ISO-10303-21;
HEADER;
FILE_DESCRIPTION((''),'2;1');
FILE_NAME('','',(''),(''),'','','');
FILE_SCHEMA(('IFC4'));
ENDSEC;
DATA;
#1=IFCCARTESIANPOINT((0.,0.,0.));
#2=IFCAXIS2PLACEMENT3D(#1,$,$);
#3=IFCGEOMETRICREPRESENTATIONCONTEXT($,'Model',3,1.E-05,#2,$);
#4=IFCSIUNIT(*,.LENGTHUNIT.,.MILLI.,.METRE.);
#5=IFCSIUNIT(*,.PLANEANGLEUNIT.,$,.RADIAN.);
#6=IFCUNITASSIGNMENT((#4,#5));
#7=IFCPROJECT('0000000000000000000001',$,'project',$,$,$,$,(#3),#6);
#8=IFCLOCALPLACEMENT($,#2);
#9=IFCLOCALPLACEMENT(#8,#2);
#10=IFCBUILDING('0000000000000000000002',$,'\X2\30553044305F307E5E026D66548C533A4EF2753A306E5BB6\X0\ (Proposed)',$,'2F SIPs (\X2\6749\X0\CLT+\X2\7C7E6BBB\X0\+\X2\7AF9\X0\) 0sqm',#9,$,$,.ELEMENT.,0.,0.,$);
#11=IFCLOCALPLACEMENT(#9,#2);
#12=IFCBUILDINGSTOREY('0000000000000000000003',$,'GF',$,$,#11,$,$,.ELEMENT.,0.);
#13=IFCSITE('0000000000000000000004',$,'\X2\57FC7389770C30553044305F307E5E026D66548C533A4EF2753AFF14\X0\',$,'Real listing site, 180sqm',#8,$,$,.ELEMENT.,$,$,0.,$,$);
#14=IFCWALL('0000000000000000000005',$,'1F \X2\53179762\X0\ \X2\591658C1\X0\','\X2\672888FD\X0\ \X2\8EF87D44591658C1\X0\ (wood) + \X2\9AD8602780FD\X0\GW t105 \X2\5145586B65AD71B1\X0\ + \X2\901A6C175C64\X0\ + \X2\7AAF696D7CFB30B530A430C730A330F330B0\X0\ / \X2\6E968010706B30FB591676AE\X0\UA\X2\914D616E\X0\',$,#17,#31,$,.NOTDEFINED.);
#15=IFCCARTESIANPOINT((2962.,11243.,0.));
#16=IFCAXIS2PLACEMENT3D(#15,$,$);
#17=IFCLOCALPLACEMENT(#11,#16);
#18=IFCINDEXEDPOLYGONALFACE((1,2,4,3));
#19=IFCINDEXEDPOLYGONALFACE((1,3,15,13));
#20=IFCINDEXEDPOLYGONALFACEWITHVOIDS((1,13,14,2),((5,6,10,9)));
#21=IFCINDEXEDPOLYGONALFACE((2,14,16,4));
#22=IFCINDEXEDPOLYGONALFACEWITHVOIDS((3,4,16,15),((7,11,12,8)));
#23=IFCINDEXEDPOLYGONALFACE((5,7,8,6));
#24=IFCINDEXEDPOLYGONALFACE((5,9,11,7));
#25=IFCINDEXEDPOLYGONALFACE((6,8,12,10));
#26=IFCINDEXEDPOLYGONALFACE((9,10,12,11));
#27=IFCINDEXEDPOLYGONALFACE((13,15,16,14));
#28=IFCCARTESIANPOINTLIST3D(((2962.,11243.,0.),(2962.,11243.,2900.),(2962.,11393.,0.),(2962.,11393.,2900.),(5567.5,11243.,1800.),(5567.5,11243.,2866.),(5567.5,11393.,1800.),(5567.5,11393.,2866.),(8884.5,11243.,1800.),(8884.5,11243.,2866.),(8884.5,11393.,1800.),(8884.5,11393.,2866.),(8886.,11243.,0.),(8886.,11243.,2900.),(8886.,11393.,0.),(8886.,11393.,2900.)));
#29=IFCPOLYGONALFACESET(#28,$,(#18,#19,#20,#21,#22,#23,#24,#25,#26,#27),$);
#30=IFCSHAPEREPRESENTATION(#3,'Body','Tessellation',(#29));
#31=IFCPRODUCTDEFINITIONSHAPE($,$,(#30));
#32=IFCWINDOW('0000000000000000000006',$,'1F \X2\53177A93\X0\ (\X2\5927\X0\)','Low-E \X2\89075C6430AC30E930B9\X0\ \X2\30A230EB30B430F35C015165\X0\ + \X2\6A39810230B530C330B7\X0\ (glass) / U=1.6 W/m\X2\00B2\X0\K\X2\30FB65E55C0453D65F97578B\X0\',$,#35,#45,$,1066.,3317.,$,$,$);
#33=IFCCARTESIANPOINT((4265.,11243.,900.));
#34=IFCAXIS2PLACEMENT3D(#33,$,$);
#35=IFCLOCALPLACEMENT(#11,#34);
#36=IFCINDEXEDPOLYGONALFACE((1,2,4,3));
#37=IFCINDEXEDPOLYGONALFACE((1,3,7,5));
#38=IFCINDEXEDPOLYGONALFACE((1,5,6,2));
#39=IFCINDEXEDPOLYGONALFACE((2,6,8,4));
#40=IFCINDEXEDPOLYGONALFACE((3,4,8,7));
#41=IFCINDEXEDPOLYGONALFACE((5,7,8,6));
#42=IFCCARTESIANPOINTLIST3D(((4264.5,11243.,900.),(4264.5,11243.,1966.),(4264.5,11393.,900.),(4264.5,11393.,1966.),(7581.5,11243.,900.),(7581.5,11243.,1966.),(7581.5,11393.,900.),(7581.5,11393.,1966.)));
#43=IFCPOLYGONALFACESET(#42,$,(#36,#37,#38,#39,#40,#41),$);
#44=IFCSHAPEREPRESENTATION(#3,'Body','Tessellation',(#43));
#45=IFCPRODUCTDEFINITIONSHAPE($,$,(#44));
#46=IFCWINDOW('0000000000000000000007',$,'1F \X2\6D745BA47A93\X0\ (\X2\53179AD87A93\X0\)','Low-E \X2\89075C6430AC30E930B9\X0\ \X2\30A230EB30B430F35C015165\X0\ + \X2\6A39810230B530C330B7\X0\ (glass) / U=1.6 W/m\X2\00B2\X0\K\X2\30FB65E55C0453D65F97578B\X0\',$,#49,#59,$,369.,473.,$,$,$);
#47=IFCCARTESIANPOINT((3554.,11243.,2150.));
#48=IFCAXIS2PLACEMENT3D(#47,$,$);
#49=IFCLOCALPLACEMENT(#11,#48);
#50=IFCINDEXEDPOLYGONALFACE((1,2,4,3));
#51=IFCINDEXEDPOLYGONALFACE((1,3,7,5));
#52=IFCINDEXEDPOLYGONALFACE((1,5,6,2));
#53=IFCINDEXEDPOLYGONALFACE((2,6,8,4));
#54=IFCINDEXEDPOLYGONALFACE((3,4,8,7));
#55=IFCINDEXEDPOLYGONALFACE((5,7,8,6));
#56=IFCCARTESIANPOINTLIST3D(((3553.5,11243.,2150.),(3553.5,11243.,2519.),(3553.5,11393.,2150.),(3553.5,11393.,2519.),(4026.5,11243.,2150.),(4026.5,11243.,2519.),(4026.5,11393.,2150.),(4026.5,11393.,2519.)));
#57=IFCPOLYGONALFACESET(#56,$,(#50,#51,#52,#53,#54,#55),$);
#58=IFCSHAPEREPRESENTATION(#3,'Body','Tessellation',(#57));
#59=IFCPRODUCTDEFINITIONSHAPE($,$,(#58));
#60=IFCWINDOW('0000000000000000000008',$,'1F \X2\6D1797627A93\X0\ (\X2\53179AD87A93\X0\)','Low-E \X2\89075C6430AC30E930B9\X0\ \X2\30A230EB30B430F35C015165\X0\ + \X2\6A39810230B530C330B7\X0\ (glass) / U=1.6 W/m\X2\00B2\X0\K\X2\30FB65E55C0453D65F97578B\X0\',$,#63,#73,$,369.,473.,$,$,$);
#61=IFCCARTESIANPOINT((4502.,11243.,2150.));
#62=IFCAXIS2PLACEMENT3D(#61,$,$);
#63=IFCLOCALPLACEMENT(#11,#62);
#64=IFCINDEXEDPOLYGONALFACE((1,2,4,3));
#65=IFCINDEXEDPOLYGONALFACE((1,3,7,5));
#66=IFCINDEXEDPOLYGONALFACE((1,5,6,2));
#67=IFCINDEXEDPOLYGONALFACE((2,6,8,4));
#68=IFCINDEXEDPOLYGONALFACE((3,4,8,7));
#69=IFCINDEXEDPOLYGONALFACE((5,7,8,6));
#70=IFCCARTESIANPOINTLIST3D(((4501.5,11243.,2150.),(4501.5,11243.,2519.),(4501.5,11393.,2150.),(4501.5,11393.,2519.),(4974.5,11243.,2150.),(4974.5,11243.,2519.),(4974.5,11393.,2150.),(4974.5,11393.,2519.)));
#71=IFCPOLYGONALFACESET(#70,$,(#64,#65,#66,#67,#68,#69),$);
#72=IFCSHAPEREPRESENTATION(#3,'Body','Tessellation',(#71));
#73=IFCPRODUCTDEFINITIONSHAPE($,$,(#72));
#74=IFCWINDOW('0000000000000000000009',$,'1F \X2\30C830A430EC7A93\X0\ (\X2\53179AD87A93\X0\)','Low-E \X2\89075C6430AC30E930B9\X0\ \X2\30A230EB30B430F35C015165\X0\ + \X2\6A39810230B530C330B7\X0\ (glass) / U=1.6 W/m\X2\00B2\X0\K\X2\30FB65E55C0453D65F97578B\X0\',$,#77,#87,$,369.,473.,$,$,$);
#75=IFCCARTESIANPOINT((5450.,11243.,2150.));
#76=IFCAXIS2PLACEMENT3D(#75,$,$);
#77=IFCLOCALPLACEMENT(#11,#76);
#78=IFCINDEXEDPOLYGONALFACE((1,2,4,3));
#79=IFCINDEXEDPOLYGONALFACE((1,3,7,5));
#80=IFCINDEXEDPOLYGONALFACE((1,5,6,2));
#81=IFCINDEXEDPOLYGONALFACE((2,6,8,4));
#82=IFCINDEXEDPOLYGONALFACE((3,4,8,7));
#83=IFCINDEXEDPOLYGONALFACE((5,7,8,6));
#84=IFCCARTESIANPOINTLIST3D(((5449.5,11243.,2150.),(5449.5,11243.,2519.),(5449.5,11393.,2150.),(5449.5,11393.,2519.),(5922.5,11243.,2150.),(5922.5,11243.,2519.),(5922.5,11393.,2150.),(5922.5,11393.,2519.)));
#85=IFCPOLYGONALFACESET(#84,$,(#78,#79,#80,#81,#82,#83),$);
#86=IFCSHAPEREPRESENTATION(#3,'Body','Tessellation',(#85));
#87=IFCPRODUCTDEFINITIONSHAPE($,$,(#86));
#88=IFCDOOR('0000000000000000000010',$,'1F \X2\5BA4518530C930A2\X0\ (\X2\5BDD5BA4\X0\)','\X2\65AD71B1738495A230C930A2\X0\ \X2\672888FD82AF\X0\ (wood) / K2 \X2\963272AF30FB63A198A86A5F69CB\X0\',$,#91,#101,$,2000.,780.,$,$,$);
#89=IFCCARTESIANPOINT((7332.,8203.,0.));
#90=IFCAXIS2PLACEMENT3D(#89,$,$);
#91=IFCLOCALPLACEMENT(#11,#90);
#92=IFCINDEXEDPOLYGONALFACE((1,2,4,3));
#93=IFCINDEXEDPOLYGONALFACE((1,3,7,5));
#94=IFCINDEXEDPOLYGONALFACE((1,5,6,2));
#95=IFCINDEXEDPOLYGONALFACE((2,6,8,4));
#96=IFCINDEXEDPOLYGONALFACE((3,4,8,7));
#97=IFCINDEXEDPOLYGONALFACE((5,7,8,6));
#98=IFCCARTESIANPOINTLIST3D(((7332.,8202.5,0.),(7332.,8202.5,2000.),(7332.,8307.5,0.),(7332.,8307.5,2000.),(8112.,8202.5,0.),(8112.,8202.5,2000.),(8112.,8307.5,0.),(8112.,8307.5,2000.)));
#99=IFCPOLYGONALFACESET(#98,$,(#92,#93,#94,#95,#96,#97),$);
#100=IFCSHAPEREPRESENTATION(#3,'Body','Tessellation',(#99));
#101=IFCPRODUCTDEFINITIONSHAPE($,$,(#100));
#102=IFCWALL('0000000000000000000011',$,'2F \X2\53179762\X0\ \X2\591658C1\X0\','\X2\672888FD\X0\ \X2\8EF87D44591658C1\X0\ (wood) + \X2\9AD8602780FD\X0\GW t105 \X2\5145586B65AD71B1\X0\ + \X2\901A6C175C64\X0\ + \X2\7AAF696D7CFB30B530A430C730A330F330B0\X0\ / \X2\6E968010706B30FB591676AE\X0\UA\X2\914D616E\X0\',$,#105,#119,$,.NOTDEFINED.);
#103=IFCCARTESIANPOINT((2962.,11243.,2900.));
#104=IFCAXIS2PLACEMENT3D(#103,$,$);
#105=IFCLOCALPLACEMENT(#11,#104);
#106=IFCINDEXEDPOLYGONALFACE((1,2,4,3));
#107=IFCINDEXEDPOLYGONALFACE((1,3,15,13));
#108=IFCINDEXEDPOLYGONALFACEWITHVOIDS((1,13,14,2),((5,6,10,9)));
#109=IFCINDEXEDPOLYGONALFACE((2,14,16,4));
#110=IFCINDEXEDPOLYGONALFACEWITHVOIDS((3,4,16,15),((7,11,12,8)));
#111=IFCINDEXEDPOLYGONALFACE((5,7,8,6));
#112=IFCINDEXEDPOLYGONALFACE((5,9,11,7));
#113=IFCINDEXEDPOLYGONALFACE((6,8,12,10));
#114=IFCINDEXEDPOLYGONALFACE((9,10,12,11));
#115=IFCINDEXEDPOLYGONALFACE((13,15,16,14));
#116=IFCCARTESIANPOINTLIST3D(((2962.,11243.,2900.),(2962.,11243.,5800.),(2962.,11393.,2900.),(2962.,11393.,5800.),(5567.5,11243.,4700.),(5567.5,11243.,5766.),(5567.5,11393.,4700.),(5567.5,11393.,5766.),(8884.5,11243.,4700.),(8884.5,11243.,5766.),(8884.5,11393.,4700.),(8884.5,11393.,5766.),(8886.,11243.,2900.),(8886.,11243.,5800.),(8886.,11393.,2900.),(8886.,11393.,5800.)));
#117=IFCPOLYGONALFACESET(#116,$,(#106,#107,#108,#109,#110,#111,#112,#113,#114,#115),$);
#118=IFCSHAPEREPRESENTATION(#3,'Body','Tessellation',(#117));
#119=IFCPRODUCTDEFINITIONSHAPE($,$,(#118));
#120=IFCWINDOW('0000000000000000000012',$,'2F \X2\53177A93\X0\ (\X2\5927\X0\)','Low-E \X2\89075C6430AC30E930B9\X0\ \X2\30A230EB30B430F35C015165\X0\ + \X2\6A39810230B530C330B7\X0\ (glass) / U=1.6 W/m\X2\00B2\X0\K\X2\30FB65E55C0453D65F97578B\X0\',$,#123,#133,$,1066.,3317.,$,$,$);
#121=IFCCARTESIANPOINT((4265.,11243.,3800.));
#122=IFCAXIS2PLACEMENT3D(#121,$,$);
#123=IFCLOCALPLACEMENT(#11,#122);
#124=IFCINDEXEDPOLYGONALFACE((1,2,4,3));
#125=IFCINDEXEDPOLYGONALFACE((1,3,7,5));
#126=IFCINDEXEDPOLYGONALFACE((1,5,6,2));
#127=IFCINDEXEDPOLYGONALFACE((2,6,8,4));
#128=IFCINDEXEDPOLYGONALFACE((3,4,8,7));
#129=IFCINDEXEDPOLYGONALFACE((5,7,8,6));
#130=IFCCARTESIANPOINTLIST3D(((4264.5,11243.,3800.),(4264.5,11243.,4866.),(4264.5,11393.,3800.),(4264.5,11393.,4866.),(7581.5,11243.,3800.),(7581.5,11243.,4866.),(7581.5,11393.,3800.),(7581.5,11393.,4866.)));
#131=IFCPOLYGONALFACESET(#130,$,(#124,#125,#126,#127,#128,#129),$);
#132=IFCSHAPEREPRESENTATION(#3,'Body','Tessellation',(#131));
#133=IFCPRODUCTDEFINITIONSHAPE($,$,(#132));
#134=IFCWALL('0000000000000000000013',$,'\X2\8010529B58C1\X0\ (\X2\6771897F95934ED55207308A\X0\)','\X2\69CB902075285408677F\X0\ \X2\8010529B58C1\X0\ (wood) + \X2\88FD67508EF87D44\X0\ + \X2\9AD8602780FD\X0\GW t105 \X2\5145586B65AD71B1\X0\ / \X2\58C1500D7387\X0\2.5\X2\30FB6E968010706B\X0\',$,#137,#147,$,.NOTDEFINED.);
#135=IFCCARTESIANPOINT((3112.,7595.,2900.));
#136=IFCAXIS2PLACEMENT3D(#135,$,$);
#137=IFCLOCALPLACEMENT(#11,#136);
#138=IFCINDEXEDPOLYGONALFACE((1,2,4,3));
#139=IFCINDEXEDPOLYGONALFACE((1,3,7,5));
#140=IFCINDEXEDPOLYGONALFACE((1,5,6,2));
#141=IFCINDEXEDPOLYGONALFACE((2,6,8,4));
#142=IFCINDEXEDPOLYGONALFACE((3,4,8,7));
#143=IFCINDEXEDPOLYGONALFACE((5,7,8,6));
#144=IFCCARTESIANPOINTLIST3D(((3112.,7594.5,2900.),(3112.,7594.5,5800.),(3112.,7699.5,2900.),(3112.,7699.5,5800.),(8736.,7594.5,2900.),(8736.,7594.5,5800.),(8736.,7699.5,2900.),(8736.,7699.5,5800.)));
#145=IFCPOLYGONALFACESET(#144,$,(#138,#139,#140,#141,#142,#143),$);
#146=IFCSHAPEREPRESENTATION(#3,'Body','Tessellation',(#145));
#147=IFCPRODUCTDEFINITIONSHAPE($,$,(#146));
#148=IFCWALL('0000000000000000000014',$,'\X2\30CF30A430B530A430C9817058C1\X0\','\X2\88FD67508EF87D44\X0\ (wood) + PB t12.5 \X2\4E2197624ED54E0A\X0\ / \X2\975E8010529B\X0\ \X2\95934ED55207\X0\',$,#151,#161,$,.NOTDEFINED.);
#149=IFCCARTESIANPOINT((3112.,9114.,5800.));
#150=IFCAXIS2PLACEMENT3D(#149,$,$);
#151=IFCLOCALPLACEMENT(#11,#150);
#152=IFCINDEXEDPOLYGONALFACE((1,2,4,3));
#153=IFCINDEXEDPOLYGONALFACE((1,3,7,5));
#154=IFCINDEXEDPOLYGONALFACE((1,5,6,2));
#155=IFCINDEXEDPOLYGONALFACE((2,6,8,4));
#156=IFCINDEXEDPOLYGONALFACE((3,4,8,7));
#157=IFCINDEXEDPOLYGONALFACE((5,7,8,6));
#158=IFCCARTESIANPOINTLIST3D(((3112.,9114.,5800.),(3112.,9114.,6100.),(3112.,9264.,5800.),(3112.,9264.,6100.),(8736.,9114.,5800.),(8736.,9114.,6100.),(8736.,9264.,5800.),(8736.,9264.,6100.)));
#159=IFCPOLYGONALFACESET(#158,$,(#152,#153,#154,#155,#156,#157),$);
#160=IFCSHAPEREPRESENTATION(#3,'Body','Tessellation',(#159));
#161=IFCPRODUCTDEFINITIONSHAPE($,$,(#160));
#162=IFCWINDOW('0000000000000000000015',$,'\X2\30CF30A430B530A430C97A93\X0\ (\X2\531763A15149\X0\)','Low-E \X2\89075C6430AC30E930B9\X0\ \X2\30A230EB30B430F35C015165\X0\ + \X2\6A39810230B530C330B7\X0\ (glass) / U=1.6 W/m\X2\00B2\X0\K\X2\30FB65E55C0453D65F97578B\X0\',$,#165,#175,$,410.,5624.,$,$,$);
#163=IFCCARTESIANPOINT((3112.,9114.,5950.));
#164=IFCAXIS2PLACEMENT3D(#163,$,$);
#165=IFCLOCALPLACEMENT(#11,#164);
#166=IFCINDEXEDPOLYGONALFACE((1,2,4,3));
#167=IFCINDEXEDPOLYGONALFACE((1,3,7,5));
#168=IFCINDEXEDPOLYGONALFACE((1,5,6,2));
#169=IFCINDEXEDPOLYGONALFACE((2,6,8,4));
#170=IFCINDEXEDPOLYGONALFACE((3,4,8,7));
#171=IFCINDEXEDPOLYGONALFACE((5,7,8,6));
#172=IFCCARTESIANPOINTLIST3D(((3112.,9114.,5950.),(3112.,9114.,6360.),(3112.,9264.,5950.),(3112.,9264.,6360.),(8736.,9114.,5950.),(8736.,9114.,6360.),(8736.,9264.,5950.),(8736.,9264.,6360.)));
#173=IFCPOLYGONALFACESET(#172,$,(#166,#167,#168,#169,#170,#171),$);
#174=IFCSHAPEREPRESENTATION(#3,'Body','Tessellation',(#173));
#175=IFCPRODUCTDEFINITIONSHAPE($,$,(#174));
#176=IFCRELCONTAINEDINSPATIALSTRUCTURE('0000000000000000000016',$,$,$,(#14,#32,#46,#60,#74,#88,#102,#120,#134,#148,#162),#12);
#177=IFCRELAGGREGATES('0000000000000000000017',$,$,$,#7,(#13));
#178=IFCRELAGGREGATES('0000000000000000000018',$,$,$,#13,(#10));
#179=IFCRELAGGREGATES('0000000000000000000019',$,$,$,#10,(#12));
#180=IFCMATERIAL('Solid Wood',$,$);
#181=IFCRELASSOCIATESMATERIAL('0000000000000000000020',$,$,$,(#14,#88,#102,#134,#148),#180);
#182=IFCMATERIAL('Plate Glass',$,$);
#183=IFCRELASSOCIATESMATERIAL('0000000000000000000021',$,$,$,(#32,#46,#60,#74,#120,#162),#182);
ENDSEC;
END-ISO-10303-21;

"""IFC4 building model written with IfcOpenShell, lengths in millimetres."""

from ifc_helpers import new_model, si_unit, frame, frame_2d, origin, place, context, project, spatial, rectangle, extrude, material, element, fill, save


model = new_model("IFC4")

# Units and contexts
model_context = context("Model", 3, precision=1e-05, world=origin())
ifc_project = project(units=[si_unit("LENGTHUNIT", "METRE", prefix="MILLI"), si_unit("PLANEANGLEUNIT", "RADIAN")], contexts=[model_context])

# Site, building, storey
site_placement = place(None, origin())
site = spatial("IfcSite", under=ifc_project, at=site_placement, Name="埼玉県さいたま市浦和区仲町４", ObjectType="Real listing site, 180sqm", CompositionType="ELEMENT", RefElevation=0.0)
building_placement = place(site_placement, origin())
building = spatial("IfcBuilding", under=site, at=building_placement, Name="さいたま市浦和区仲町の家 (Proposed)", ObjectType="2F SIPs (杉CLT+籾殻+竹) 0sqm", CompositionType="ELEMENT", ElevationOfRefHeight=0.0, ElevationOfTerrain=0.0)
storey_placement = place(building_placement, origin())
storey = spatial("IfcBuildingStorey", under=building, at=storey_placement, Name="GF", CompositionType="ELEMENT", Elevation=0.0)

# Wall, openings, windows
ifc_material_1 = material(Name="Solid Wood")
wall_1_placement = place(storey_placement, frame((2962.0, 11243.0, 0.0)))
wall_1 = element("IfcWall", 1, at=wall_1_placement, inside=storey, material=ifc_material_1, Name="1F 北面 外壁", Description="木製 軸組外壁 (wood) + 高性能GW t105 充填断熱 + 通気層 + 窯業系サイディング / 準耐火・外皮UA配慮", PredefinedType="NOTDEFINED", context=model_context, shape_type="SweptSolid", body=[
    extrude(rectangle(XDim=5924.0, YDim=150.0, at=frame_2d((2962.0, 75.0))), frame((2962.0, 11243.0, 0.0)), (0.0, 0.0, 1.0), 2900.0),
])
opening_1_placement = place(storey_placement, frame((4265.0, 11243.0, 900.0)))
opening_1 = element("IfcOpeningElement", 2, at=opening_1_placement, cuts=wall_1, PredefinedType="NOTDEFINED", context=model_context, shape_type="SweptSolid", body=[
    extrude(rectangle(XDim=3317.0, YDim=150.0, at=frame_2d((1658.0, 75.0))), frame((4265.0, 11243.0, 900.0)), (0.0, 0.0, 1.0), 1066.0),
])
opening_2_placement = place(storey_placement, frame((3554.0, 11243.0, 2150.0)))
opening_2 = element("IfcOpeningElement", 3, at=opening_2_placement, cuts=wall_1, PredefinedType="NOTDEFINED", context=model_context, shape_type="SweptSolid", body=[
    extrude(rectangle(XDim=473.0, YDim=150.0, at=frame_2d((236.0, 75.0))), frame((3554.0, 11243.0, 2150.0)), (0.0, 0.0, 1.0), 369.0),
])
opening_3_placement = place(storey_placement, frame((4502.0, 11243.0, 2150.0)))
opening_3 = element("IfcOpeningElement", 4, at=opening_3_placement, cuts=wall_1, PredefinedType="NOTDEFINED", context=model_context, shape_type="SweptSolid", body=[
    extrude(rectangle(XDim=473.0, YDim=150.0, at=frame_2d((236.0, 75.0))), frame((4502.0, 11243.0, 2150.0)), (0.0, 0.0, 1.0), 369.0),
])
opening_4_placement = place(storey_placement, frame((5450.0, 11243.0, 2150.0)))
opening_4 = element("IfcOpeningElement", 5, at=opening_4_placement, cuts=wall_1, PredefinedType="NOTDEFINED", context=model_context, shape_type="SweptSolid", body=[
    extrude(rectangle(XDim=473.0, YDim=150.0, at=frame_2d((236.0, 75.0))), frame((5450.0, 11243.0, 2150.0)), (0.0, 0.0, 1.0), 369.0),
])
ifc_material_2 = material(Name="Plate Glass")
window_1_placement = place(storey_placement, frame((4265.0, 11243.0, 900.0)))
window_1 = element("IfcWindow", 6, at=window_1_placement, inside=storey, material=ifc_material_2, Name="1F 北窓 (大)", Description="Low-E 複層ガラス アルゴン封入 + 樹脂サッシ (glass) / U=1.6 W/m²K・日射取得型", OverallHeight=1066.0, OverallWidth=3317.0, context=model_context, shape_type="SweptSolid", body=[
    extrude(rectangle(XDim=3317.0, YDim=150.0, at=frame_2d((1658.0, 75.0))), frame((4265.0, 11243.0, 900.0)), (0.0, 0.0, 1.0), 1066.0),
])
fill(opening_1, window_1)
window_2_placement = place(storey_placement, frame((3554.0, 11243.0, 2150.0)))
window_2 = element("IfcWindow", 7, at=window_2_placement, inside=storey, material=ifc_material_2, Name="1F 浴室窓 (北高窓)", Description="Low-E 複層ガラス アルゴン封入 + 樹脂サッシ (glass) / U=1.6 W/m²K・日射取得型", OverallHeight=369.0, OverallWidth=473.0, context=model_context, shape_type="SweptSolid", body=[
    extrude(rectangle(XDim=473.0, YDim=150.0, at=frame_2d((236.0, 75.0))), frame((3554.0, 11243.0, 2150.0)), (0.0, 0.0, 1.0), 369.0),
])
fill(opening_2, window_2)
window_3_placement = place(storey_placement, frame((4502.0, 11243.0, 2150.0)))
window_3 = element("IfcWindow", 8, at=window_3_placement, inside=storey, material=ifc_material_2, Name="1F 洗面窓 (北高窓)", Description="Low-E 複層ガラス アルゴン封入 + 樹脂サッシ (glass) / U=1.6 W/m²K・日射取得型", OverallHeight=369.0, OverallWidth=473.0, context=model_context, shape_type="SweptSolid", body=[
    extrude(rectangle(XDim=473.0, YDim=150.0, at=frame_2d((236.0, 75.0))), frame((4502.0, 11243.0, 2150.0)), (0.0, 0.0, 1.0), 369.0),
])
fill(opening_3, window_3)
window_4_placement = place(storey_placement, frame((5450.0, 11243.0, 2150.0)))
window_4 = element("IfcWindow", 9, at=window_4_placement, inside=storey, material=ifc_material_2, Name="1F トイレ窓 (北高窓)", Description="Low-E 複層ガラス アルゴン封入 + 樹脂サッシ (glass) / U=1.6 W/m²K・日射取得型", OverallHeight=369.0, OverallWidth=473.0, context=model_context, shape_type="SweptSolid", body=[
    extrude(rectangle(XDim=473.0, YDim=150.0, at=frame_2d((236.0, 75.0))), frame((5450.0, 11243.0, 2150.0)), (0.0, 0.0, 1.0), 369.0),
])
fill(opening_4, window_4)

# Door
door_1_placement = place(storey_placement, frame((7332.0, 8203.0, 0.0)))
element("IfcDoor", 10, at=door_1_placement, inside=storey, material=ifc_material_1, Name="1F 室内ドア (寝室)", Description="断熱玄関ドア 木製芯 (wood) / K2 防犯・採風機構", OverallHeight=2000.0, OverallWidth=780.0, context=model_context, shape_type="SweptSolid", body=[
    extrude(rectangle(XDim=780.0, YDim=105.0, at=frame_2d((390.0, 52.0))), frame((7332.0, 8203.0, 0.0)), (0.0, 0.0, 1.0), 2000.0),
])

# Wall, opening, window
wall_2_placement = place(storey_placement, frame((2962.0, 11243.0, 2900.0)))
wall_2 = element("IfcWall", 11, at=wall_2_placement, inside=storey, material=ifc_material_1, Name="2F 北面 外壁", Description="木製 軸組外壁 (wood) + 高性能GW t105 充填断熱 + 通気層 + 窯業系サイディング / 準耐火・外皮UA配慮", PredefinedType="NOTDEFINED", context=model_context, shape_type="SweptSolid", body=[
    extrude(rectangle(XDim=5924.0, YDim=150.0, at=frame_2d((2962.0, 75.0))), frame((2962.0, 11243.0, 2900.0)), (0.0, 0.0, 1.0), 2900.0),
])
opening_5_placement = place(storey_placement, frame((4265.0, 11243.0, 3800.0)))
opening_5 = element("IfcOpeningElement", 12, at=opening_5_placement, cuts=wall_2, PredefinedType="NOTDEFINED", context=model_context, shape_type="SweptSolid", body=[
    extrude(rectangle(XDim=3317.0, YDim=150.0, at=frame_2d((1658.0, 75.0))), frame((4265.0, 11243.0, 3800.0)), (0.0, 0.0, 1.0), 1066.0),
])
window_5_placement = place(storey_placement, frame((4265.0, 11243.0, 3800.0)))
window_5 = element("IfcWindow", 13, at=window_5_placement, inside=storey, material=ifc_material_2, Name="2F 北窓 (大)", Description="Low-E 複層ガラス アルゴン封入 + 樹脂サッシ (glass) / U=1.6 W/m²K・日射取得型", OverallHeight=1066.0, OverallWidth=3317.0, context=model_context, shape_type="SweptSolid", body=[
    extrude(rectangle(XDim=3317.0, YDim=150.0, at=frame_2d((1658.0, 75.0))), frame((4265.0, 11243.0, 3800.0)), (0.0, 0.0, 1.0), 1066.0),
])
fill(opening_5, window_5)

# Wall
wall_3_placement = place(storey_placement, frame((3112.0, 7595.0, 2900.0)))
element("IfcWall", 14, at=wall_3_placement, inside=storey, material=ifc_material_1, Name="耐力壁 (東西間仕切り)", Description="構造用合板 耐力壁 (wood) + 製材軸組 + 高性能GW t105 充填断熱 / 壁倍率2.5・準耐火", PredefinedType="NOTDEFINED", context=model_context, shape_type="SweptSolid", body=[
    extrude(rectangle(XDim=5624.0, YDim=105.0, at=frame_2d((2812.0, 52.0))), frame((3112.0, 7595.0, 2900.0)), (0.0, 0.0, 1.0), 2900.0),
])

# Wall, opening, window
wall_4_placement = place(storey_placement, frame((3112.0, 9114.0, 5800.0)))
wall_4 = element("IfcWall", 15, at=wall_4_placement, inside=storey, material=ifc_material_1, Name="ハイサイド腰壁", Description="製材軸組 (wood) + PB t12.5 両面仕上 / 非耐力 間仕切", PredefinedType="NOTDEFINED", context=model_context, shape_type="SweptSolid", body=[
    extrude(rectangle(XDim=5624.0, YDim=150.0, at=frame_2d((2812.0, 75.0))), frame((3112.0, 9114.0, 5800.0)), (0.0, 0.0, 1.0), 700.0),
])
opening_6_placement = place(storey_placement, frame((3112.0, 9114.0, 5950.0)))
opening_6 = element("IfcOpeningElement", 16, at=opening_6_placement, cuts=wall_4, PredefinedType="NOTDEFINED", context=model_context, shape_type="SweptSolid", body=[
    extrude(rectangle(XDim=5624.0, YDim=150.0, at=frame_2d((2812.0, 75.0))), frame((3112.0, 9114.0, 5950.0)), (0.0, 0.0, 1.0), 410.0),
])
window_6_placement = place(storey_placement, frame((3112.0, 9114.0, 5950.0)))
window_6 = element("IfcWindow", 17, at=window_6_placement, inside=storey, material=ifc_material_2, Name="ハイサイド窓 (北採光)", Description="Low-E 複層ガラス アルゴン封入 + 樹脂サッシ (glass) / U=1.6 W/m²K・日射取得型", OverallHeight=410.0, OverallWidth=5624.0, context=model_context, shape_type="SweptSolid", body=[
    extrude(rectangle(XDim=5624.0, YDim=150.0, at=frame_2d((2812.0, 75.0))), frame((3112.0, 9114.0, 5950.0)), (0.0, 0.0, 1.0), 410.0),
])
fill(opening_6, window_6)

save(model, "model.ifc")
